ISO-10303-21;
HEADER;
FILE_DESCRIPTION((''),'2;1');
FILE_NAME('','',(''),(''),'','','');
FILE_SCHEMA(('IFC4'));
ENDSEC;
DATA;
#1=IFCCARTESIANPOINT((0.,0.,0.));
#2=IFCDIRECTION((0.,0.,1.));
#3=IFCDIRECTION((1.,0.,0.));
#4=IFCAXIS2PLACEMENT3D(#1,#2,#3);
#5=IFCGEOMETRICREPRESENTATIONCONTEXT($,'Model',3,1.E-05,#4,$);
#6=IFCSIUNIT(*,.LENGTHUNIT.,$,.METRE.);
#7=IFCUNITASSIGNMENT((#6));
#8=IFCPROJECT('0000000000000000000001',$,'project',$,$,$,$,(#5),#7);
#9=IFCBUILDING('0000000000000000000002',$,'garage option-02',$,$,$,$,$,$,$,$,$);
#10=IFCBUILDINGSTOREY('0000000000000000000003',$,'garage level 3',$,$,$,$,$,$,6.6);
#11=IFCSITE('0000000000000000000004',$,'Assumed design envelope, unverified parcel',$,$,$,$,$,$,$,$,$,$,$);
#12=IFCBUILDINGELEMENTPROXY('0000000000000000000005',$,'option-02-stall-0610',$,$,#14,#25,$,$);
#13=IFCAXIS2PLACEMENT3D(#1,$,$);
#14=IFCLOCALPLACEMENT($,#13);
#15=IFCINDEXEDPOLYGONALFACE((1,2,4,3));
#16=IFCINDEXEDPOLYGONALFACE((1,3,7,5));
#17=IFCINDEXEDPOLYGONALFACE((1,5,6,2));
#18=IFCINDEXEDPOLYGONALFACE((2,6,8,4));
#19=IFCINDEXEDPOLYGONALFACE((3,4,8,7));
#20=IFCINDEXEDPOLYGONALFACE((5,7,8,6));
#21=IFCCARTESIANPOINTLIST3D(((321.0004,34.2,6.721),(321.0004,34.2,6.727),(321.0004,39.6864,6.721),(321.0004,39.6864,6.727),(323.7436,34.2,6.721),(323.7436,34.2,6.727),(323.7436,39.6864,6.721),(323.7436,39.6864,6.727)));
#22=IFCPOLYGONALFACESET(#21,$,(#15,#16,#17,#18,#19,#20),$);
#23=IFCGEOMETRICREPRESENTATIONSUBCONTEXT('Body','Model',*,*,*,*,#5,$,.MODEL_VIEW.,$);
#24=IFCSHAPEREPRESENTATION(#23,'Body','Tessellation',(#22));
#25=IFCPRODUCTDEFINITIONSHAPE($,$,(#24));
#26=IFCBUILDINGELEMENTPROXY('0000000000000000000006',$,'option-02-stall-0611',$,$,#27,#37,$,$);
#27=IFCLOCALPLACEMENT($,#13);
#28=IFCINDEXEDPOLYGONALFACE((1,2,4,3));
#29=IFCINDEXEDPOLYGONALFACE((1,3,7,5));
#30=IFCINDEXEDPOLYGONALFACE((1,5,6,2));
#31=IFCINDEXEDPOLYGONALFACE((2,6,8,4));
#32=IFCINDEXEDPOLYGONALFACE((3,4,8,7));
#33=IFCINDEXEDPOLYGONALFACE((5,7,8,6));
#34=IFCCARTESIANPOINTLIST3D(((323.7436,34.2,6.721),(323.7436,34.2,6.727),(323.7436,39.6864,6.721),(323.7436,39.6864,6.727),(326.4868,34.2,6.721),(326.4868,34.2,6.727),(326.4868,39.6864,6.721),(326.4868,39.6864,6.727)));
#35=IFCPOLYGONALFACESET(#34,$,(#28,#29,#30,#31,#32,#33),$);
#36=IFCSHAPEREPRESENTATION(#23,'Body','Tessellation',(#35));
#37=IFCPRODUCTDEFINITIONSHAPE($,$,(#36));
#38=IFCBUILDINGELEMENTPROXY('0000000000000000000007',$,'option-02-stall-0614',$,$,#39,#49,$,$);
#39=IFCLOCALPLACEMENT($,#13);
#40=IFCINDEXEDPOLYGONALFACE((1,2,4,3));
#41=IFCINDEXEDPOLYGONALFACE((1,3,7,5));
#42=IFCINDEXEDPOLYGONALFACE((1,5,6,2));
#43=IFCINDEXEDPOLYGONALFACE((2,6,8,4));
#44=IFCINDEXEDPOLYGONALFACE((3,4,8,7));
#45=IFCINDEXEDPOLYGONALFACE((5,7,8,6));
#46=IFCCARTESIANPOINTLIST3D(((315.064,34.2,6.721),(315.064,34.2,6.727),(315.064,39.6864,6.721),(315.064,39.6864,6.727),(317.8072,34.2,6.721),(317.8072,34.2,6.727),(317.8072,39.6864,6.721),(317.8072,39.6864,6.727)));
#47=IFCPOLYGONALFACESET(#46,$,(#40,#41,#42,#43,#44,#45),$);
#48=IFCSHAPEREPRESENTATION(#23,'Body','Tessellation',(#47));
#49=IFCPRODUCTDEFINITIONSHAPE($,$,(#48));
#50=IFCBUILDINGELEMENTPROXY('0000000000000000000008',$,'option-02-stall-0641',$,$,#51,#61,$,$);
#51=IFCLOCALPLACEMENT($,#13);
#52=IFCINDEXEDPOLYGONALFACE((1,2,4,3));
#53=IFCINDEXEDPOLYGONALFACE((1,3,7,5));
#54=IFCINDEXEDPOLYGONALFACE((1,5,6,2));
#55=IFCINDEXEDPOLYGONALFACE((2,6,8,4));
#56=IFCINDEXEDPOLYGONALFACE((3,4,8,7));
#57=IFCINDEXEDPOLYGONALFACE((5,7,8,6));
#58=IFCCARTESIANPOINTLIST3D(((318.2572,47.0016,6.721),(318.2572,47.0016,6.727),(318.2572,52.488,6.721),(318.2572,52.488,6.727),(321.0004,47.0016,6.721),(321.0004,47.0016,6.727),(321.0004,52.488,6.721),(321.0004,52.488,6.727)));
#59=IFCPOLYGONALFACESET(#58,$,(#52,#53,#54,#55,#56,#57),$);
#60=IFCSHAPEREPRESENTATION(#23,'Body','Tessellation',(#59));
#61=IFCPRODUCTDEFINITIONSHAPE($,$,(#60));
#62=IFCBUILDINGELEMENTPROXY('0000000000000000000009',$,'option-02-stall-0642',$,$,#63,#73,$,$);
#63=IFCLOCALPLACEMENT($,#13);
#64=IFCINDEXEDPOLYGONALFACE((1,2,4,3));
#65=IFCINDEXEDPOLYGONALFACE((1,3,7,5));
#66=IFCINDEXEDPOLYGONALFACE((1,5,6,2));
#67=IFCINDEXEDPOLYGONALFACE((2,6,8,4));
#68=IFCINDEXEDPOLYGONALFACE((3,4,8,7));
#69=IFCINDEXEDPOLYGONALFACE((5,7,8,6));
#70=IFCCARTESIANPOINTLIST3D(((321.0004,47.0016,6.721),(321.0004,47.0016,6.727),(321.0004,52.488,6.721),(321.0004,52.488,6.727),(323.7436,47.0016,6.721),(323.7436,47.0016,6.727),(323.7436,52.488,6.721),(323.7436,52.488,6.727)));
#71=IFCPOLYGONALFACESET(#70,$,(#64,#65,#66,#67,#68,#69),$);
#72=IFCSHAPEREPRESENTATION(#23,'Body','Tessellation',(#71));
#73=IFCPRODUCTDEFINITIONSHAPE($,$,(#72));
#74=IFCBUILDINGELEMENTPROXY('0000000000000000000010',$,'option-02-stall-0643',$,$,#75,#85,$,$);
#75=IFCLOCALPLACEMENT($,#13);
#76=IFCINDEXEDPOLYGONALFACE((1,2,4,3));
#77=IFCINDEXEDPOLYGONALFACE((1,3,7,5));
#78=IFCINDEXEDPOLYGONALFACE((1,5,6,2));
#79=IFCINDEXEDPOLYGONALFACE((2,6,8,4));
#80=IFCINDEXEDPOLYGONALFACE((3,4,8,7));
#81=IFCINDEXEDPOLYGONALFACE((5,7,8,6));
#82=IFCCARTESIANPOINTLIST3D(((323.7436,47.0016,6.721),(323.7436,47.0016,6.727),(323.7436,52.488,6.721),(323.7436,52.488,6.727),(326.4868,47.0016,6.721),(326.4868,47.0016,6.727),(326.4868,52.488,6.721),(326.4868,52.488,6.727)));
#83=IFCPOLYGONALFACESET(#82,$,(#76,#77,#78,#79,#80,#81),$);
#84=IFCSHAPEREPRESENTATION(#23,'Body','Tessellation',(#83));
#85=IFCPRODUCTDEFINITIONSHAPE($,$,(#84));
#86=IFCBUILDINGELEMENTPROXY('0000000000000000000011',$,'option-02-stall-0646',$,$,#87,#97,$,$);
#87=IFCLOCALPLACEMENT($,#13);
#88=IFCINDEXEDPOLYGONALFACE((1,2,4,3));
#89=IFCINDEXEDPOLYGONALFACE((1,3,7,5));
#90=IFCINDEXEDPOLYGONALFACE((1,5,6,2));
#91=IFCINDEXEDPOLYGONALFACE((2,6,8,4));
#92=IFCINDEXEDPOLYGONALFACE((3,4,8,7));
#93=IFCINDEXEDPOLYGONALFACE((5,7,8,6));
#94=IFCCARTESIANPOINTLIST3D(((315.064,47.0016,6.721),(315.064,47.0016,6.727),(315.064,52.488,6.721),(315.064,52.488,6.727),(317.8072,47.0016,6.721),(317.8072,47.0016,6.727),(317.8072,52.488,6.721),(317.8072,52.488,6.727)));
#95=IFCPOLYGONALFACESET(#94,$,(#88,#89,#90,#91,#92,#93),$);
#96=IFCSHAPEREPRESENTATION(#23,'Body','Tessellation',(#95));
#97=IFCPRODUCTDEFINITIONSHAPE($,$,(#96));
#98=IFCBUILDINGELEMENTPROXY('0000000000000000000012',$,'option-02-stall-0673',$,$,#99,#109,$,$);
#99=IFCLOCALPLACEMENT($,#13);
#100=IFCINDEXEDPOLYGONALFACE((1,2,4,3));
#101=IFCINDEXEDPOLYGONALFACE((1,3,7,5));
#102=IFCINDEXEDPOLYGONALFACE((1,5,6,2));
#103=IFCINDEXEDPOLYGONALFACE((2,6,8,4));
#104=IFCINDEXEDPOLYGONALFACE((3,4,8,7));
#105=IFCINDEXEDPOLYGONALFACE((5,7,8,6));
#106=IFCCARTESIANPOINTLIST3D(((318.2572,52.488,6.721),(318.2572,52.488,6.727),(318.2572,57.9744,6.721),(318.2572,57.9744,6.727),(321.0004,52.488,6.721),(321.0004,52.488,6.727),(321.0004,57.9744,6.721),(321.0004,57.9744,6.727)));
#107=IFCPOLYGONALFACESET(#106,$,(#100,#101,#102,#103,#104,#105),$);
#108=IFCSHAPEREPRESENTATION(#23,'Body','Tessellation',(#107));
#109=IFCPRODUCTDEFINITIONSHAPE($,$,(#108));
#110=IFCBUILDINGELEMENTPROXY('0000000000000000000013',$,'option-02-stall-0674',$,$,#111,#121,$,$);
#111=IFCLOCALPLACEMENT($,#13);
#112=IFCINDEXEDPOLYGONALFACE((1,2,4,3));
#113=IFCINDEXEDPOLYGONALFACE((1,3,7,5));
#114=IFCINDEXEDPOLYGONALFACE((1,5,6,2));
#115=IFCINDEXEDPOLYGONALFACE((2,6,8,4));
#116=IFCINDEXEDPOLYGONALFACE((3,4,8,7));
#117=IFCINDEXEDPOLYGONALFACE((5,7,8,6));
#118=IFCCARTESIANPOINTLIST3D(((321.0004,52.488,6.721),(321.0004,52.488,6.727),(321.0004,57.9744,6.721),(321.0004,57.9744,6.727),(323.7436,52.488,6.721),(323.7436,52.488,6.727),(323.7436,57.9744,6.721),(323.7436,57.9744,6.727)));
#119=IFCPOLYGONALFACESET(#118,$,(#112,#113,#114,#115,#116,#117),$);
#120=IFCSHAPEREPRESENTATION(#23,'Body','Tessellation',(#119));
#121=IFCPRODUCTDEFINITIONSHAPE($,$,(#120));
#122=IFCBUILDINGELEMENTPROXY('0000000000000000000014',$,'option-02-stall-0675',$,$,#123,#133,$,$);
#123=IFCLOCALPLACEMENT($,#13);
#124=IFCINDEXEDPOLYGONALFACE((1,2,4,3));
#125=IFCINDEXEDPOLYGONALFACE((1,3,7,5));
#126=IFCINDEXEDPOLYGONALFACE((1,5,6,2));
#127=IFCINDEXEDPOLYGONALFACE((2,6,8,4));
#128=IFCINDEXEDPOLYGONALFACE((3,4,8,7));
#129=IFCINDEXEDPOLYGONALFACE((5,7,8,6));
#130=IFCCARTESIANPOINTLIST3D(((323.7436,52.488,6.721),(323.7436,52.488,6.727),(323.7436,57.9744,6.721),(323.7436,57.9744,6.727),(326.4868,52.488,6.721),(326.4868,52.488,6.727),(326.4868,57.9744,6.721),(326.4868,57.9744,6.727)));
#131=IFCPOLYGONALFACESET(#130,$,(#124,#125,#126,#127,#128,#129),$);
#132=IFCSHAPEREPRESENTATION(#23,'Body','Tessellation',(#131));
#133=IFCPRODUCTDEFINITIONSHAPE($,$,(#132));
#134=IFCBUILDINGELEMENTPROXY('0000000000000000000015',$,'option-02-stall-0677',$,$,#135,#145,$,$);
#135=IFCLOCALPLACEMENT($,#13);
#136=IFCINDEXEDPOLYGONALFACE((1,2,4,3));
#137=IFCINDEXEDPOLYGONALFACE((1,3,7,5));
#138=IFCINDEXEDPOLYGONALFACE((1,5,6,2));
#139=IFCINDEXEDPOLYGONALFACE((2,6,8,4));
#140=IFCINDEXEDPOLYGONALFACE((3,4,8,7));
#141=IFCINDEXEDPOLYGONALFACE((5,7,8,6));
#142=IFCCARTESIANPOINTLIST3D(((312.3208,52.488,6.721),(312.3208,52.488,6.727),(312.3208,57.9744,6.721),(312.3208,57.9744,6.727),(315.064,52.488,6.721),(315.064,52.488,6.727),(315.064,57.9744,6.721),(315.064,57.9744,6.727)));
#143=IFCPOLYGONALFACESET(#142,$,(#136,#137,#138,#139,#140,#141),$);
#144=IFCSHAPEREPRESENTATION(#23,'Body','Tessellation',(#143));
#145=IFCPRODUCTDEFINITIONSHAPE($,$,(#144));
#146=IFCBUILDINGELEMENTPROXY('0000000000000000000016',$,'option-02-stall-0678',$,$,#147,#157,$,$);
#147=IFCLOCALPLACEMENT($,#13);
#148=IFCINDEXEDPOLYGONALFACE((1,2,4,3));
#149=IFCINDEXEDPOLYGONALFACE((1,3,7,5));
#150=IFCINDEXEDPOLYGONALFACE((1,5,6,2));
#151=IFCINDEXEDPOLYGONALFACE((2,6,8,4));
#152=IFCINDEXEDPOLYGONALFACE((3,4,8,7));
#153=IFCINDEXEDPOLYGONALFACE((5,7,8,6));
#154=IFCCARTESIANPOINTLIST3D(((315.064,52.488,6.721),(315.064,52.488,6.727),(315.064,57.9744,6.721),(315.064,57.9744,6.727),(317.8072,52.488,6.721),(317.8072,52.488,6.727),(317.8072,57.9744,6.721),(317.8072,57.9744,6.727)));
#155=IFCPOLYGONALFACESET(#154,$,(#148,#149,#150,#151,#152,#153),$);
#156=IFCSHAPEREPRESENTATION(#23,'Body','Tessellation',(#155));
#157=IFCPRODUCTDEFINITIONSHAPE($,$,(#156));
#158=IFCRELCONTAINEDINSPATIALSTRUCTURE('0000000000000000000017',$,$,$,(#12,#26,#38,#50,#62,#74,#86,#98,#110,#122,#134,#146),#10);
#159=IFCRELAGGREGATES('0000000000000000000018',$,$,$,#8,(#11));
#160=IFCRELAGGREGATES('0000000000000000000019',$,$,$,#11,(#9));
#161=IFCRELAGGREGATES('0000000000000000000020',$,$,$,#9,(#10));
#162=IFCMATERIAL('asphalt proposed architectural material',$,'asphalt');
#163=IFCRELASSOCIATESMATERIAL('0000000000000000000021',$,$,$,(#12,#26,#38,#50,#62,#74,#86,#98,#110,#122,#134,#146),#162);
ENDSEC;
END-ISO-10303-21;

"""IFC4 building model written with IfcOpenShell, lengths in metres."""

from ifc_helpers import new_model, si_unit, frame, origin_with_axes, place, context, subcontext, project, spatial, rectangle, extrude, material, element, save


model = new_model("IFC4")

# Units and contexts
model_context = context("Model", 3, precision=1e-05, world=origin_with_axes())
body_context = subcontext(model_context, "Body", "Model", "MODEL_VIEW")
ifc_project = project(units=[si_unit("LENGTHUNIT", "METRE")], contexts=[model_context])

# Site, building, storey
site = spatial("IfcSite", under=ifc_project, Name="Assumed design envelope, unverified parcel")
building = spatial("IfcBuilding", under=site, Name="garage option-02")
storey = spatial("IfcBuildingStorey", under=building, Name="garage level 3", Elevation=6.6)

# Building element proxies
ifc_material_1 = material(Name="asphalt proposed architectural material", Category="asphalt")
for number, where, z_axis, x_axis, name in (
    (1, (322.372, 36.9432, 6.721), (0.0, 0.0, 1.0), (1.0, 0.0, 0.0), "option-02-stall-0610"),
    (2, (325.1152, 36.9432, 6.721), (0.0, 0.0, 1.0), (1.0, 0.0, 0.0), "option-02-stall-0611"),
    (3, (316.4356, 36.9432, 6.721), (0.0, 0.0, 1.0), (1.0, 0.0, 0.0), "option-02-stall-0614"),
    (4, (319.6288, 49.7448, 6.721), (0.0, 0.0, 1.0), (1.0, 0.0, 0.0), "option-02-stall-0641"),
    (5, (322.372, 49.7448, 6.721), (0.0, 0.0, 1.0), (1.0, 0.0, 0.0), "option-02-stall-0642"),
    (6, (325.1152, 49.7448, 6.721), (0.0, 0.0, 1.0), (1.0, 0.0, 0.0), "option-02-stall-0643"),
    (7, (316.4356, 49.7448, 6.721), (0.0, 0.0, 1.0), (1.0, 0.0, 0.0), "option-02-stall-0646"),
):
    element("IfcBuildingElementProxy", number, at=place(None, frame(where, z_axis=z_axis, x_axis=x_axis)), inside=storey, material=ifc_material_1, Name=name, context=body_context, shape_type="SweptSolid", body=[
        extrude(rectangle(XDim=2.7432, YDim=5.4864), origin_with_axes(), (0.0, 0.0, 1.0), 0.006),
    ])
for number, where, z_axis, x_axis, name in (
    (8, (319.6288, 55.2312, 6.721), (0.0, 0.0, 1.0), (1.0, 0.0, 0.0), "option-02-stall-0673"),
    (9, (322.372, 55.2312, 6.721), (0.0, 0.0, 1.0), (1.0, 0.0, 0.0), "option-02-stall-0674"),
    (10, (325.1152, 55.2312, 6.721), (0.0, 0.0, 1.0), (1.0, 0.0, 0.0), "option-02-stall-0675"),
    (11, (313.6924, 55.2312, 6.721), (0.0, 0.0, 1.0), (1.0, 0.0, 0.0), "option-02-stall-0677"),
    (12, (316.4356, 55.2312, 6.721), (0.0, 0.0, 1.0), (1.0, 0.0, 0.0), "option-02-stall-0678"),
):
    element("IfcBuildingElementProxy", number, at=place(None, frame(where, z_axis=z_axis, x_axis=x_axis)), inside=storey, material=ifc_material_1, Name=name, context=body_context, shape_type="SweptSolid", body=[
        extrude(rectangle(XDim=2.7432, YDim=5.4864), origin_with_axes(), (0.0, 0.0, 1.0), 0.006),
    ])

save(model, "model.ifc")
